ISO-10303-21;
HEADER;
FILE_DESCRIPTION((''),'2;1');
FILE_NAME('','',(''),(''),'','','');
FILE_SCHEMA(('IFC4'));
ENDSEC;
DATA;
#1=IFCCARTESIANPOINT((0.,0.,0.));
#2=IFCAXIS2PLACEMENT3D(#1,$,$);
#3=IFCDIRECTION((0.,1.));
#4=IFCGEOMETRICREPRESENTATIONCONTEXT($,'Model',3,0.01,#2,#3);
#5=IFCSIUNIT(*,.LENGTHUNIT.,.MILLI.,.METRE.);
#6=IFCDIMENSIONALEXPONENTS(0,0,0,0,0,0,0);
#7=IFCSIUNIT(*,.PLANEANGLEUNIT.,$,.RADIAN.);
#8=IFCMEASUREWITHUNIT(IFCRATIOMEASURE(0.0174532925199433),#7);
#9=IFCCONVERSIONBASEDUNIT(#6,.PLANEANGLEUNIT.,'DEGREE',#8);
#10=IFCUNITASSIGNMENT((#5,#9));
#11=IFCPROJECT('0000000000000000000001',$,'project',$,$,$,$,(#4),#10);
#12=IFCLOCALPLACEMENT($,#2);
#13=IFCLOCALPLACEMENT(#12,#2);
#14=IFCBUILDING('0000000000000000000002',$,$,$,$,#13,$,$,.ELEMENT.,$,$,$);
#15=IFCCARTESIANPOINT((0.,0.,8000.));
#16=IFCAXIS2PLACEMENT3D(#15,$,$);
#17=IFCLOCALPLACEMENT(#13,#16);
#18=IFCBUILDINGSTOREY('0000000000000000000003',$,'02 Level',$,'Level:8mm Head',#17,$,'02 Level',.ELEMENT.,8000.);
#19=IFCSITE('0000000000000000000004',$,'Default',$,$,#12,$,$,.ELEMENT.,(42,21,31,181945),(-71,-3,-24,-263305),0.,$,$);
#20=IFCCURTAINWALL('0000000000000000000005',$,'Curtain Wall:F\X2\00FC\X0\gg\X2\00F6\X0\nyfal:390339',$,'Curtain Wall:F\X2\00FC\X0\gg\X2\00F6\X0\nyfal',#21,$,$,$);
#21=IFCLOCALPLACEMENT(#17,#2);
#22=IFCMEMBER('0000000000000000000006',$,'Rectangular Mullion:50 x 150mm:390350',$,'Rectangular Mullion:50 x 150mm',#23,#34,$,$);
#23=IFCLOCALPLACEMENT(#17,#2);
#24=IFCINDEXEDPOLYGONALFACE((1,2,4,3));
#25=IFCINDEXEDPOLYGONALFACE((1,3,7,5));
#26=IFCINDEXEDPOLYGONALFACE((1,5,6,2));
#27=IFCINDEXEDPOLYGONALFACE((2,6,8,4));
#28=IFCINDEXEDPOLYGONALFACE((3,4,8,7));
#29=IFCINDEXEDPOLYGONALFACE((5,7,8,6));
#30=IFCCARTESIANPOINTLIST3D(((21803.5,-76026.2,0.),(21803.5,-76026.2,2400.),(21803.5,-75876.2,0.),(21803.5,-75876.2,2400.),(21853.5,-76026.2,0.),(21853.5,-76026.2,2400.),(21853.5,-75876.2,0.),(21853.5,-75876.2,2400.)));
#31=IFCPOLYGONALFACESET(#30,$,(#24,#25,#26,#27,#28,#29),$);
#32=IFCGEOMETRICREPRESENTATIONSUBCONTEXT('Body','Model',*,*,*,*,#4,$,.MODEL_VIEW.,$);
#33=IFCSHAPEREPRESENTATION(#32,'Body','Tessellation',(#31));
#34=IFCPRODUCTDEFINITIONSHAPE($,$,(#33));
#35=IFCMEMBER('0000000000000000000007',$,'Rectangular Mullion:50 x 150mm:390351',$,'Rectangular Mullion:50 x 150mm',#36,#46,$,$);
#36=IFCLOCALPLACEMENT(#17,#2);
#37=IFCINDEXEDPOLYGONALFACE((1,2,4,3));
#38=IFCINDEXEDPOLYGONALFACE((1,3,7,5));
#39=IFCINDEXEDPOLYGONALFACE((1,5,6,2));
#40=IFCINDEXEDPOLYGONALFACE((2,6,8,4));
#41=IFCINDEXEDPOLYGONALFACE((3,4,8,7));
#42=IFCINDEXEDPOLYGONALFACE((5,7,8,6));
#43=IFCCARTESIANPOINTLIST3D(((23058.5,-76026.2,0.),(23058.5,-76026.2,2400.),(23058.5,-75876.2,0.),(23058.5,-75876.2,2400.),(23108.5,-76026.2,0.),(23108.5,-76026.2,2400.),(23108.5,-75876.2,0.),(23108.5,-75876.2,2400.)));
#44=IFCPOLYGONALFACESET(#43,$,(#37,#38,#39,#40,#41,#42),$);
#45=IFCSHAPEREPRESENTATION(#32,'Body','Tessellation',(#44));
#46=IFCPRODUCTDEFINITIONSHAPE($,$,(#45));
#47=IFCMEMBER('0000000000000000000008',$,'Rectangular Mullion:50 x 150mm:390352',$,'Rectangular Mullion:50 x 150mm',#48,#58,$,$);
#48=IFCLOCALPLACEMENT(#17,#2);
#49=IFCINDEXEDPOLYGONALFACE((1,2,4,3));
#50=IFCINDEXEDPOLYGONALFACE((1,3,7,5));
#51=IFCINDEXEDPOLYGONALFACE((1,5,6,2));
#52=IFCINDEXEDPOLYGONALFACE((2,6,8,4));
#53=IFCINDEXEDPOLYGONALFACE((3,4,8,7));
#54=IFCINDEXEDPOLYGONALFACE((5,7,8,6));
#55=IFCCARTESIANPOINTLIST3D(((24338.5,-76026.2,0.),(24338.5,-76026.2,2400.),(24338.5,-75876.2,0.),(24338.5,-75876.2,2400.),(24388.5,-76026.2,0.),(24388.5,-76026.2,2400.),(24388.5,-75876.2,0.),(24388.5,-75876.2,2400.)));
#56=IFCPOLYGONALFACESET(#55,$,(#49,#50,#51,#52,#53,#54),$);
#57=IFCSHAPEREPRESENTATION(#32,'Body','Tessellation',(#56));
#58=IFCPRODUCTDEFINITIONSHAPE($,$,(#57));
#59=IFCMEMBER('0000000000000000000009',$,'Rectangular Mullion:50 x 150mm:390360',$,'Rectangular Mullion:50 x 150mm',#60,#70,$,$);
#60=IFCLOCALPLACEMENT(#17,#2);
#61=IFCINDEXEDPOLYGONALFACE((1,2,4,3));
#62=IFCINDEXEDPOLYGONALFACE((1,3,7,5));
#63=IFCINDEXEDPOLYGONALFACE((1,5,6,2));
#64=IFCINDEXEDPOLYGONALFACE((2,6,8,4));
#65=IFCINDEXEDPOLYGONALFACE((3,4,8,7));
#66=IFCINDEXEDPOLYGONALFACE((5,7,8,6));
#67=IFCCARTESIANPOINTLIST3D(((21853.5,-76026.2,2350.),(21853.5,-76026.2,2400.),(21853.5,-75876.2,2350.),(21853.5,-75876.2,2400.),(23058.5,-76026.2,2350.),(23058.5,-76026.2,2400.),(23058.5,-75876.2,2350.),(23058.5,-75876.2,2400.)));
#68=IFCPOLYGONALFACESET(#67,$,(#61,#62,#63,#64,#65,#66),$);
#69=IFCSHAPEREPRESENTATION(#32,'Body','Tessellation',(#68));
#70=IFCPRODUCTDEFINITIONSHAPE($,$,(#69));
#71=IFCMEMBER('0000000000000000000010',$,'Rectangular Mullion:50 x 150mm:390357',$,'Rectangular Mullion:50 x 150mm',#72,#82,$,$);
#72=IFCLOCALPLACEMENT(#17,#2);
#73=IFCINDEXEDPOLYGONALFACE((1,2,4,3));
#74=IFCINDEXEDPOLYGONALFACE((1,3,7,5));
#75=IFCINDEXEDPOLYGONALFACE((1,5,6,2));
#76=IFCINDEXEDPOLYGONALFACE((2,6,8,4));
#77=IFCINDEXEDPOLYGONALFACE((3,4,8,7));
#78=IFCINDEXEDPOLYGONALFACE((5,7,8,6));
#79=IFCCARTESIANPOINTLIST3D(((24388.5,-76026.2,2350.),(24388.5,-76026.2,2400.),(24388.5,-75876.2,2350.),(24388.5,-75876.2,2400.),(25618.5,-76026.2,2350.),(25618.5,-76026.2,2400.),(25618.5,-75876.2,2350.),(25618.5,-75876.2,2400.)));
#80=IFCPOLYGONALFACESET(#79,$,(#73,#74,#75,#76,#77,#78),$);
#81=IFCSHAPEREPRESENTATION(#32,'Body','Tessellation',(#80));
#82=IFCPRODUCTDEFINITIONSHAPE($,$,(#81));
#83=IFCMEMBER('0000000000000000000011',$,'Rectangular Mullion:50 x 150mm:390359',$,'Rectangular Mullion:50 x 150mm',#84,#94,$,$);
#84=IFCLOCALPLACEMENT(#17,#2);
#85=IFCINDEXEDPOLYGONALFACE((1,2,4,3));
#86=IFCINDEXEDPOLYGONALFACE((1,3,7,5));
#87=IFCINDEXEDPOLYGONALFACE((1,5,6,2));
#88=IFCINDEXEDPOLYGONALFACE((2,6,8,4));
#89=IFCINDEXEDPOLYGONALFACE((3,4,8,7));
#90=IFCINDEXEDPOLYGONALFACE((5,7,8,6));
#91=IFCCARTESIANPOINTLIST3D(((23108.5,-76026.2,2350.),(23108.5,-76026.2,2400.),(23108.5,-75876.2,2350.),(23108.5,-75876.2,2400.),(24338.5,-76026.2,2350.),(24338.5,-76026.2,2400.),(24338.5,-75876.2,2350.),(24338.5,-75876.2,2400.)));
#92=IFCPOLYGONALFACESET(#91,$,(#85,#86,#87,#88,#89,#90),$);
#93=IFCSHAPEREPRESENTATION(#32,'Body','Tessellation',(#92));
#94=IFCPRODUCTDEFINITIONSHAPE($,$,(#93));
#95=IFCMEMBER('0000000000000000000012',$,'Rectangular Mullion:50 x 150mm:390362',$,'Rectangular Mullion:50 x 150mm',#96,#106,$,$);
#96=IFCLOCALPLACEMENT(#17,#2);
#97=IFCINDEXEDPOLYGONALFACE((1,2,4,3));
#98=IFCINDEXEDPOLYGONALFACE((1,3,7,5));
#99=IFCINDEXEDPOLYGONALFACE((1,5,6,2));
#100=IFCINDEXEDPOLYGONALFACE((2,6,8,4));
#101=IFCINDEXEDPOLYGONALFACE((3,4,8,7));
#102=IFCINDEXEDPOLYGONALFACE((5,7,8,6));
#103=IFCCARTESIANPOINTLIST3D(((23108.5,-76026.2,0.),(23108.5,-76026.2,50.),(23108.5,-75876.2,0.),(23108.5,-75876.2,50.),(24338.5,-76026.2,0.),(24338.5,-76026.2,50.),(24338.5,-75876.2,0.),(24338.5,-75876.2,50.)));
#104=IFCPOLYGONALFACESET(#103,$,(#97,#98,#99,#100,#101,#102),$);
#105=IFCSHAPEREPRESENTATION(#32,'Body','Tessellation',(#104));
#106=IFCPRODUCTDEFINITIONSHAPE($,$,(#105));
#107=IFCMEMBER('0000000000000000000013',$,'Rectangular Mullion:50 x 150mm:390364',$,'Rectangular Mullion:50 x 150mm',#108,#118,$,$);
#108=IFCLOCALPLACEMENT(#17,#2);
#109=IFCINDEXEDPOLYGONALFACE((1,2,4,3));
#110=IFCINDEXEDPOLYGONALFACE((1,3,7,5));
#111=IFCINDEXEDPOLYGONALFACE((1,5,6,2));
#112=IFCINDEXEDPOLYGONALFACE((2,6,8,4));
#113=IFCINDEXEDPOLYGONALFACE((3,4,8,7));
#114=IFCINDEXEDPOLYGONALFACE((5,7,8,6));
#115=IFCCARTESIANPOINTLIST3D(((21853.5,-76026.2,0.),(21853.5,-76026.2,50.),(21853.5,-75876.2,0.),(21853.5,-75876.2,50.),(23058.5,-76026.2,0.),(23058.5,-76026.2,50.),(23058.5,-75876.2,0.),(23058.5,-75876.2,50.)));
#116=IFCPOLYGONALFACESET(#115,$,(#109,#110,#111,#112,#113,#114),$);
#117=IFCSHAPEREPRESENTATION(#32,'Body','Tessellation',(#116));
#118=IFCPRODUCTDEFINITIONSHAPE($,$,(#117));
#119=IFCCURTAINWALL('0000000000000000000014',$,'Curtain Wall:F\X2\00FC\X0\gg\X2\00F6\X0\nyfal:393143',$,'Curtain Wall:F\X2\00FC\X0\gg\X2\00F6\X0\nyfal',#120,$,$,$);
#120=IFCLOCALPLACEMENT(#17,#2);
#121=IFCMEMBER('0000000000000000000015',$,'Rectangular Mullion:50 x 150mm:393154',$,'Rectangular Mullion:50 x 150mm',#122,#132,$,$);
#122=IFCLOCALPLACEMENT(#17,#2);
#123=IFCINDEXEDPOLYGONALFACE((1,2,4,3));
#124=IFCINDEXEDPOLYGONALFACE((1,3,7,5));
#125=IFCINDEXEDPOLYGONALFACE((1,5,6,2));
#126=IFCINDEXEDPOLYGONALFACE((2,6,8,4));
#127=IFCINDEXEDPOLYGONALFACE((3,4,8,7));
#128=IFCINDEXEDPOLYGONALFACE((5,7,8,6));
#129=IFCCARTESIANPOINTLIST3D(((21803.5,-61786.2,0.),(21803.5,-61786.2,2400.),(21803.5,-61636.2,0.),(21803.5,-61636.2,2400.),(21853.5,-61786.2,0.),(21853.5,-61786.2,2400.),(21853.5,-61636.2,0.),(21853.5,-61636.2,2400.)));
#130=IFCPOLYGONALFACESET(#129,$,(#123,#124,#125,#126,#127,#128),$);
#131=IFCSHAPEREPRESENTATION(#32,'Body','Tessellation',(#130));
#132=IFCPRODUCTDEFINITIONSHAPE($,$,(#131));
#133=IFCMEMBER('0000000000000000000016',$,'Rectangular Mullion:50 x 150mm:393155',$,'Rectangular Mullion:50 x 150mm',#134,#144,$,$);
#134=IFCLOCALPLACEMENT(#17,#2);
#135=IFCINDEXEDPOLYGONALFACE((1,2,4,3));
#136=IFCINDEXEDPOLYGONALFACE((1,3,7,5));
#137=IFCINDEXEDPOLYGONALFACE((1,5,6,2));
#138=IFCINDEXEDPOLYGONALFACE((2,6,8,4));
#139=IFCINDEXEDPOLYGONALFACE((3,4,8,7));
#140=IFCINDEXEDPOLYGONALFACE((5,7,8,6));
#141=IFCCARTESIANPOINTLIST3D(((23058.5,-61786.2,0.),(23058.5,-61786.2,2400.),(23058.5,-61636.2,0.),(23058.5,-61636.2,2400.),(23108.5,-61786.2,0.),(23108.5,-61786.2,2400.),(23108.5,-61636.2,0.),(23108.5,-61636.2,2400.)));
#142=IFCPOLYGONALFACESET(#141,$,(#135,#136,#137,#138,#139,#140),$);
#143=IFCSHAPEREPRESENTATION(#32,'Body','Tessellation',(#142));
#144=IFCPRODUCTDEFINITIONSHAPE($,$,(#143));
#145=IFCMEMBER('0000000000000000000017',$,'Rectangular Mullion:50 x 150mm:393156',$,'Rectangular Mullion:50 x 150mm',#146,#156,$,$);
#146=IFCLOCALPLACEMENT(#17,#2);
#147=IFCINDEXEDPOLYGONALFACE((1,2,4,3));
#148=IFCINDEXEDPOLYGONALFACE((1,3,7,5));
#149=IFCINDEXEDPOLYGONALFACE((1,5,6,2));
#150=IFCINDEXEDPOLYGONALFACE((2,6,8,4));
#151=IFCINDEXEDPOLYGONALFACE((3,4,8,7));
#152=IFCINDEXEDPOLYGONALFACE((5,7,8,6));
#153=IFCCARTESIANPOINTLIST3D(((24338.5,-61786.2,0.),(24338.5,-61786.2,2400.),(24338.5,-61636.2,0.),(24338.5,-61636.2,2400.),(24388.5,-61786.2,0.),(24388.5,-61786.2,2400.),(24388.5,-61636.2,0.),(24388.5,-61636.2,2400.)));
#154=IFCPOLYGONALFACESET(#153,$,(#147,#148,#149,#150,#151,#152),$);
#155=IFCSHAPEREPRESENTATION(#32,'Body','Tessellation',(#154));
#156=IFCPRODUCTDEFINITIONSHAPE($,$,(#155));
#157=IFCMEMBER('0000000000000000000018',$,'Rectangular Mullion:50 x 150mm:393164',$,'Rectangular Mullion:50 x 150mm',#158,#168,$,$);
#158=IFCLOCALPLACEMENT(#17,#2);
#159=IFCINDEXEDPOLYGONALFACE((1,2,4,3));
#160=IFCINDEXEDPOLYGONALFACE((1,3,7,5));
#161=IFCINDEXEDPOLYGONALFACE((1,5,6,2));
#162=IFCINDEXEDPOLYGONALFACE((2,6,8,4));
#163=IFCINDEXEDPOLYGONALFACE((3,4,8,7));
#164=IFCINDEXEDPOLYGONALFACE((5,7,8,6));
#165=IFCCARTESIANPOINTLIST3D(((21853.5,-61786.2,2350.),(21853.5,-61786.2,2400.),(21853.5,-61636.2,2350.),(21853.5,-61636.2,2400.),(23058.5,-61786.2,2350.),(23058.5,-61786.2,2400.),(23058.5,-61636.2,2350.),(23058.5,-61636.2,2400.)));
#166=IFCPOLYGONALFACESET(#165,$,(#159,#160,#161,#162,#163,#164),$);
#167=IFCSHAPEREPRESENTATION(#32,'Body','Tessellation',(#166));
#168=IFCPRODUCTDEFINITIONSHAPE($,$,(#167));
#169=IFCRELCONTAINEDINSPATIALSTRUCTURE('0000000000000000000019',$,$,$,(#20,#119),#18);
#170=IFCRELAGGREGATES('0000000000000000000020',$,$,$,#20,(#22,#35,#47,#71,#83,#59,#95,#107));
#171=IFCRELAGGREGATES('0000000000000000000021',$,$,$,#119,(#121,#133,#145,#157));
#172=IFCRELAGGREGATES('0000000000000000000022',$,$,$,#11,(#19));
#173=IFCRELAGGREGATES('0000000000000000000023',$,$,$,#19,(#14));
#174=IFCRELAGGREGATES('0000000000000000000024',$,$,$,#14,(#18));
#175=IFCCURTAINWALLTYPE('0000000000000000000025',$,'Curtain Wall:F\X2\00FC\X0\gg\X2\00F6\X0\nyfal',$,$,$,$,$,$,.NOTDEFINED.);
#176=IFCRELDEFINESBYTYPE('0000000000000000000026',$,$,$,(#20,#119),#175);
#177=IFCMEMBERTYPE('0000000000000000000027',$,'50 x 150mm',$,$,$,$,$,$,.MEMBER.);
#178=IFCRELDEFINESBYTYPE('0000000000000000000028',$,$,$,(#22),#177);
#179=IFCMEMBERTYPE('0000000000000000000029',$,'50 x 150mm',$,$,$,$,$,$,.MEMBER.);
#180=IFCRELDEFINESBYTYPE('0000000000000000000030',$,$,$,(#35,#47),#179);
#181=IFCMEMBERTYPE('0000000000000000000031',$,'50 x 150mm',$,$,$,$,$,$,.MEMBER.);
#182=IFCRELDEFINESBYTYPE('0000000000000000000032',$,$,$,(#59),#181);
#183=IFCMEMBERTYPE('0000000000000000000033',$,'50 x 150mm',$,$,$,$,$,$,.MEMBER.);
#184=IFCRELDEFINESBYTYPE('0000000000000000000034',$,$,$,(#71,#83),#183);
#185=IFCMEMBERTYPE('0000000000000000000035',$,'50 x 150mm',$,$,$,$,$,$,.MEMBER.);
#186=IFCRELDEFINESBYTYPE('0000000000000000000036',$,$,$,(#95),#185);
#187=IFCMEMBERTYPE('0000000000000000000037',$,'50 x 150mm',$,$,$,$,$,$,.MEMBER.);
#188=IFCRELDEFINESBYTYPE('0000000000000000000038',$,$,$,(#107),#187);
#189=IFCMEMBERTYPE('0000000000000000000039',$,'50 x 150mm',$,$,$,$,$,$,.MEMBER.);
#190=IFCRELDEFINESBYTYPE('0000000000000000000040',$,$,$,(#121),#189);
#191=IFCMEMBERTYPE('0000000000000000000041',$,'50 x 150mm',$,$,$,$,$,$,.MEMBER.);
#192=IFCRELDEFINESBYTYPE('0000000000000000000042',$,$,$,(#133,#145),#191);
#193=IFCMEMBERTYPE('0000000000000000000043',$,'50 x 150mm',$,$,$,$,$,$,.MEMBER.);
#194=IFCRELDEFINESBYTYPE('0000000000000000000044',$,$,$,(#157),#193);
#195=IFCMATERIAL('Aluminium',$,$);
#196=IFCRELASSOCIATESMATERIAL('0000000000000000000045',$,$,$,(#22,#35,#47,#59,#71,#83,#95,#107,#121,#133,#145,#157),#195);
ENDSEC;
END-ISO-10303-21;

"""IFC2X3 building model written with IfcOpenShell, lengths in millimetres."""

from ifc_helpers import new_model, entity, si_unit, converted_unit, direction, frame, origin, origin_2d_with_axis, place, context, subcontext, project, spatial, rectangle, extrude, source, transform, mapped, material, type_object, type_shapes, element, aggregate, save


model = new_model("IFC2X3")

# Units and contexts
model_context = context("Model", 3, precision=0.01, world=origin(), true_north=direction((0.0, 1.0)))
body_context = subcontext(model_context, "Body", "Model", "MODEL_VIEW")
ifc_project = project(units=[si_unit("LENGTHUNIT", "METRE", prefix="MILLI"), converted_unit("PLANEANGLEUNIT", "DEGREE", entity("IfcRatioMeasure", 0.0174532925199433), si_unit("PLANEANGLEUNIT", "RADIAN"), dimensions=[0, 0, 0, 0, 0, 0, 0])], contexts=[model_context])

# Site, building, storey
site_placement = place(None, origin())
site = spatial("IfcSite", under=ifc_project, at=site_placement, Name="Default", CompositionType="ELEMENT", RefLatitude=(42, 21, 31, 181945), RefLongitude=(-71, -3, -24, -263305), RefElevation=0.0)
building_placement = place(site_placement, origin())
building = spatial("IfcBuilding", under=site, at=building_placement, CompositionType="ELEMENT")
storey_placement = place(building_placement, frame((0.0, 0.0, 8000.0)))
storey = spatial("IfcBuildingStorey", under=building, at=storey_placement, Name="02 Level", ObjectType="Level:8mm Head", LongName="02 Level", CompositionType="ELEMENT", Elevation=8000.0)

# Curtain walls, members
curtain_wall_type = type_object("IfcCurtainWallType", Name="Curtain Wall:Függönyfal", PredefinedType="NOTDEFINED")
curtain_wall_1_placement = place(storey_placement, frame((0.0, 0.0, -8000.0)))
curtain_wall_1 = element("IfcCurtainWall", 1, at=curtain_wall_1_placement, inside=storey, type_object=curtain_wall_type, Name="Curtain Wall:Függönyfal:390339", ObjectType="Curtain Wall:Függönyfal")
ifc_material_1 = material(Name="Aluminium")
member_type_1 = type_object("IfcMemberType", Name="50 x 150mm", PredefinedType="MEMBER")
shared_shape_1 = source(origin(), body_context, "Body", "SweptSolid", [
    extrude(rectangle(XDim=150.0, YDim=50.0, at=origin_2d_with_axis()), frame((-25.0, 0.0, -2400.0), z_axis=(0.0, 0.0, 1.0), x_axis=(0.0, -1.0, 0.0)), (0.0, 0.0, 1.0), 2400.0),
])
type_shapes(member_type_1, [shared_shape_1])
member_1_placement = place(storey_placement, frame((21803.5, -75951.2, 0.0), z_axis=(0.0, 0.0, -1.0), x_axis=(-1.0, 0.0, 0.0)))
member_1 = element("IfcMember", 2, at=member_1_placement, type_object=member_type_1, material=ifc_material_1, Name="Rectangular Mullion:50 x 150mm:390350", ObjectType="Rectangular Mullion:50 x 150mm", context=body_context, shape_type="MappedRepresentation", body=[
    mapped(shared_shape_1, transform((0.0, 0.0, 0.0), scale=1.0)),
])
member_type_2 = type_object("IfcMemberType", Name="50 x 150mm", PredefinedType="MEMBER")
shared_shape_2 = source(origin(), body_context, "Body", "SweptSolid", [
    extrude(rectangle(XDim=150.0, YDim=50.0, at=origin_2d_with_axis()), frame((0.0, 0.0, -2400.0), z_axis=(0.0, 0.0, 1.0), x_axis=(0.0, -1.0, 0.0)), (0.0, 0.0, 1.0), 2400.0),
])
type_shapes(member_type_2, [shared_shape_2])
member_2_placement = place(storey_placement, frame((23083.5, -75951.2, 0.0), z_axis=(0.0, 0.0, -1.0), x_axis=(-1.0, 0.0, 0.0)))
member_2 = element("IfcMember", 3, at=member_2_placement, type_object=member_type_2, material=ifc_material_1, Name="Rectangular Mullion:50 x 150mm:390351", ObjectType="Rectangular Mullion:50 x 150mm", context=body_context, shape_type="MappedRepresentation", body=[
    mapped(shared_shape_2, transform((0.0, 0.0, 0.0), scale=1.0)),
])
member_3_placement = place(storey_placement, frame((24363.5, -75951.2, 0.0), z_axis=(0.0, 0.0, -1.0), x_axis=(-1.0, 0.0, 0.0)))
member_3 = element("IfcMember", 4, at=member_3_placement, type_object=member_type_2, material=ifc_material_1, Name="Rectangular Mullion:50 x 150mm:390352", ObjectType="Rectangular Mullion:50 x 150mm", context=body_context, shape_type="MappedRepresentation", body=[
    mapped(shared_shape_2, transform((0.0, 0.0, 0.0), scale=1.0)),
])
member_type_3 = type_object("IfcMemberType", Name="50 x 150mm", PredefinedType="MEMBER")
shared_shape_3 = source(origin(), body_context, "Body", "SweptSolid", [
    extrude(rectangle(XDim=150.0, YDim=50.0, at=origin_2d_with_axis()), frame((-25.0, 0.0, -1205.0), z_axis=(0.0, 0.0, 1.0), x_axis=(0.0, -1.0, 0.0)), (0.0, 0.0, 1.0), 1205.0),
])
type_shapes(member_type_3, [shared_shape_3])
member_4_placement = place(storey_placement, frame((21853.5, -75951.2, 2400.0), z_axis=(-1.0, 0.0, 0.0), x_axis=(0.0, 0.0, 1.0)))
member_4 = element("IfcMember", 5, at=member_4_placement, type_object=member_type_3, material=ifc_material_1, Name="Rectangular Mullion:50 x 150mm:390360", ObjectType="Rectangular Mullion:50 x 150mm", context=body_context, shape_type="MappedRepresentation", body=[
    mapped(shared_shape_3, transform((0.0, 0.0, 0.0), scale=1.0)),
])
member_type_4 = type_object("IfcMemberType", Name="50 x 150mm", PredefinedType="MEMBER")
shared_shape_4 = source(origin(), body_context, "Body", "SweptSolid", [
    extrude(rectangle(XDim=150.0, YDim=50.0, at=origin_2d_with_axis()), frame((-25.0, 0.0, -1230.0), z_axis=(0.0, 0.0, 1.0), x_axis=(0.0, -1.0, 0.0)), (0.0, 0.0, 1.0), 1230.0),
])
type_shapes(member_type_4, [shared_shape_4])
member_5_placement = place(storey_placement, frame((24388.5, -75951.2, 2400.0), z_axis=(-1.0, 0.0, 0.0), x_axis=(0.0, 0.0, 1.0)))
member_5 = element("IfcMember", 6, at=member_5_placement, type_object=member_type_4, material=ifc_material_1, Name="Rectangular Mullion:50 x 150mm:390357", ObjectType="Rectangular Mullion:50 x 150mm", context=body_context, shape_type="MappedRepresentation", body=[
    mapped(shared_shape_4, transform((0.0, 0.0, 0.0), scale=1.0)),
])
member_6_placement = place(storey_placement, frame((23108.5, -75951.2, 2400.0), z_axis=(-1.0, 0.0, 0.0), x_axis=(0.0, 0.0, 1.0)))
member_6 = element("IfcMember", 7, at=member_6_placement, type_object=member_type_4, material=ifc_material_1, Name="Rectangular Mullion:50 x 150mm:390359", ObjectType="Rectangular Mullion:50 x 150mm", context=body_context, shape_type="MappedRepresentation", body=[
    mapped(shared_shape_4, transform((0.0, 0.0, 0.0), scale=1.0)),
])
member_type_5 = type_object("IfcMemberType", Name="50 x 150mm", PredefinedType="MEMBER")
shared_shape_5 = source(origin(), body_context, "Body", "SweptSolid", [
    extrude(rectangle(XDim=150.0, YDim=50.0, at=origin_2d_with_axis()), frame((-25.0, 0.0, -1230.0), z_axis=(0.0, 0.0, 1.0), x_axis=(0.0, -1.0, 0.0)), (0.0, 0.0, 1.0), 1230.0),
])
type_shapes(member_type_5, [shared_shape_5])
member_7_placement = place(storey_placement, frame((24338.5, -75951.2, 0.0), z_axis=(1.0, 0.0, 0.0), x_axis=(0.0, 0.0, -1.0)))
member_7 = element("IfcMember", 8, at=member_7_placement, type_object=member_type_5, material=ifc_material_1, Name="Rectangular Mullion:50 x 150mm:390362", ObjectType="Rectangular Mullion:50 x 150mm", context=body_context, shape_type="MappedRepresentation", body=[
    mapped(shared_shape_5, transform((0.0, 0.0, 0.0), scale=1.0)),
])
member_type_6 = type_object("IfcMemberType", Name="50 x 150mm", PredefinedType="MEMBER")
shared_shape_6 = source(origin(), body_context, "Body", "SweptSolid", [
    extrude(rectangle(XDim=150.0, YDim=50.0, at=origin_2d_with_axis()), frame((-25.0, 0.0, -1205.0), z_axis=(0.0, 0.0, 1.0), x_axis=(0.0, -1.0, 0.0)), (0.0, 0.0, 1.0), 1205.0),
])
type_shapes(member_type_6, [shared_shape_6])
member_8_placement = place(storey_placement, frame((23058.5, -75951.2, 0.0), z_axis=(1.0, 0.0, 0.0), x_axis=(0.0, 0.0, -1.0)))
member_8 = element("IfcMember", 9, at=member_8_placement, type_object=member_type_6, material=ifc_material_1, Name="Rectangular Mullion:50 x 150mm:390364", ObjectType="Rectangular Mullion:50 x 150mm", context=body_context, shape_type="MappedRepresentation", body=[
    mapped(shared_shape_6, transform((0.0, 0.0, 0.0), scale=1.0)),
])
curtain_wall_2_placement = place(storey_placement, frame((0.0, 0.0, -8000.0)))
curtain_wall_2 = element("IfcCurtainWall", 10, at=curtain_wall_2_placement, inside=storey, type_object=curtain_wall_type, Name="Curtain Wall:Függönyfal:393143", ObjectType="Curtain Wall:Függönyfal")
member_type_7 = type_object("IfcMemberType", Name="50 x 150mm", PredefinedType="MEMBER")
shared_shape_7 = source(origin(), body_context, "Body", "SweptSolid", [
    extrude(rectangle(XDim=150.0, YDim=50.0, at=origin_2d_with_axis()), frame((-25.0, 0.0, -2400.0), z_axis=(0.0, 0.0, 1.0), x_axis=(0.0, -1.0, 0.0)), (0.0, 0.0, 1.0), 2400.0),
])
type_shapes(member_type_7, [shared_shape_7])
member_9_placement = place(storey_placement, frame((21803.5, -61711.2, 0.0), z_axis=(0.0, 0.0, -1.0), x_axis=(-1.0, 0.0, 0.0)))
member_9 = element("IfcMember", 11, at=member_9_placement, type_object=member_type_7, material=ifc_material_1, Name="Rectangular Mullion:50 x 150mm:393154", ObjectType="Rectangular Mullion:50 x 150mm", context=body_context, shape_type="MappedRepresentation", body=[
    mapped(shared_shape_7, transform((0.0, 0.0, 0.0), scale=1.0)),
])
member_type_8 = type_object("IfcMemberType", Name="50 x 150mm", PredefinedType="MEMBER")
shared_shape_8 = source(origin(), body_context, "Body", "SweptSolid", [
    extrude(rectangle(XDim=150.0, YDim=50.0, at=origin_2d_with_axis()), frame((0.0, 0.0, -2400.0), z_axis=(0.0, 0.0, 1.0), x_axis=(0.0, -1.0, 0.0)), (0.0, 0.0, 1.0), 2400.0),
])
type_shapes(member_type_8, [shared_shape_8])
member_10_placement = place(storey_placement, frame((23083.5, -61711.2, 0.0), z_axis=(0.0, 0.0, -1.0), x_axis=(-1.0, 0.0, 0.0)))
member_10 = element("IfcMember", 12, at=member_10_placement, type_object=member_type_8, material=ifc_material_1, Name="Rectangular Mullion:50 x 150mm:393155", ObjectType="Rectangular Mullion:50 x 150mm", context=body_context, shape_type="MappedRepresentation", body=[
    mapped(shared_shape_8, transform((0.0, 0.0, 0.0), scale=1.0)),
])
member_11_placement = place(storey_placement, frame((24363.5, -61711.2, 0.0), z_axis=(0.0, 0.0, -1.0), x_axis=(-1.0, 0.0, 0.0)))
member_11 = element("IfcMember", 13, at=member_11_placement, type_object=member_type_8, material=ifc_material_1, Name="Rectangular Mullion:50 x 150mm:393156", ObjectType="Rectangular Mullion:50 x 150mm", context=body_context, shape_type="MappedRepresentation", body=[
    mapped(shared_shape_8, transform((0.0, 0.0, 0.0), scale=1.0)),
])
member_type_9 = type_object("IfcMemberType", Name="50 x 150mm", PredefinedType="MEMBER")
shared_shape_9 = source(origin(), body_context, "Body", "SweptSolid", [
    extrude(rectangle(XDim=150.0, YDim=50.0, at=origin_2d_with_axis()), frame((-25.0, 0.0, -1205.0), z_axis=(0.0, 0.0, 1.0), x_axis=(0.0, -1.0, 0.0)), (0.0, 0.0, 1.0), 1205.0),
])
type_shapes(member_type_9, [shared_shape_9])
member_12_placement = place(storey_placement, frame((21853.5, -61711.2, 2400.0), z_axis=(-1.0, 0.0, 0.0), x_axis=(0.0, 0.0, 1.0)))
member_12 = element("IfcMember", 14, at=member_12_placement, type_object=member_type_9, material=ifc_material_1, Name="Rectangular Mullion:50 x 150mm:393164", ObjectType="Rectangular Mullion:50 x 150mm", context=body_context, shape_type="MappedRepresentation", body=[
    mapped(shared_shape_9, transform((0.0, 0.0, 0.0), scale=1.0)),
])

aggregate(curtain_wall_1, [member_1, member_2, member_3, member_5, member_6, member_4, member_7, member_8])
aggregate(curtain_wall_2, [member_9, member_10, member_11, member_12])

save(model, "model.ifc")
